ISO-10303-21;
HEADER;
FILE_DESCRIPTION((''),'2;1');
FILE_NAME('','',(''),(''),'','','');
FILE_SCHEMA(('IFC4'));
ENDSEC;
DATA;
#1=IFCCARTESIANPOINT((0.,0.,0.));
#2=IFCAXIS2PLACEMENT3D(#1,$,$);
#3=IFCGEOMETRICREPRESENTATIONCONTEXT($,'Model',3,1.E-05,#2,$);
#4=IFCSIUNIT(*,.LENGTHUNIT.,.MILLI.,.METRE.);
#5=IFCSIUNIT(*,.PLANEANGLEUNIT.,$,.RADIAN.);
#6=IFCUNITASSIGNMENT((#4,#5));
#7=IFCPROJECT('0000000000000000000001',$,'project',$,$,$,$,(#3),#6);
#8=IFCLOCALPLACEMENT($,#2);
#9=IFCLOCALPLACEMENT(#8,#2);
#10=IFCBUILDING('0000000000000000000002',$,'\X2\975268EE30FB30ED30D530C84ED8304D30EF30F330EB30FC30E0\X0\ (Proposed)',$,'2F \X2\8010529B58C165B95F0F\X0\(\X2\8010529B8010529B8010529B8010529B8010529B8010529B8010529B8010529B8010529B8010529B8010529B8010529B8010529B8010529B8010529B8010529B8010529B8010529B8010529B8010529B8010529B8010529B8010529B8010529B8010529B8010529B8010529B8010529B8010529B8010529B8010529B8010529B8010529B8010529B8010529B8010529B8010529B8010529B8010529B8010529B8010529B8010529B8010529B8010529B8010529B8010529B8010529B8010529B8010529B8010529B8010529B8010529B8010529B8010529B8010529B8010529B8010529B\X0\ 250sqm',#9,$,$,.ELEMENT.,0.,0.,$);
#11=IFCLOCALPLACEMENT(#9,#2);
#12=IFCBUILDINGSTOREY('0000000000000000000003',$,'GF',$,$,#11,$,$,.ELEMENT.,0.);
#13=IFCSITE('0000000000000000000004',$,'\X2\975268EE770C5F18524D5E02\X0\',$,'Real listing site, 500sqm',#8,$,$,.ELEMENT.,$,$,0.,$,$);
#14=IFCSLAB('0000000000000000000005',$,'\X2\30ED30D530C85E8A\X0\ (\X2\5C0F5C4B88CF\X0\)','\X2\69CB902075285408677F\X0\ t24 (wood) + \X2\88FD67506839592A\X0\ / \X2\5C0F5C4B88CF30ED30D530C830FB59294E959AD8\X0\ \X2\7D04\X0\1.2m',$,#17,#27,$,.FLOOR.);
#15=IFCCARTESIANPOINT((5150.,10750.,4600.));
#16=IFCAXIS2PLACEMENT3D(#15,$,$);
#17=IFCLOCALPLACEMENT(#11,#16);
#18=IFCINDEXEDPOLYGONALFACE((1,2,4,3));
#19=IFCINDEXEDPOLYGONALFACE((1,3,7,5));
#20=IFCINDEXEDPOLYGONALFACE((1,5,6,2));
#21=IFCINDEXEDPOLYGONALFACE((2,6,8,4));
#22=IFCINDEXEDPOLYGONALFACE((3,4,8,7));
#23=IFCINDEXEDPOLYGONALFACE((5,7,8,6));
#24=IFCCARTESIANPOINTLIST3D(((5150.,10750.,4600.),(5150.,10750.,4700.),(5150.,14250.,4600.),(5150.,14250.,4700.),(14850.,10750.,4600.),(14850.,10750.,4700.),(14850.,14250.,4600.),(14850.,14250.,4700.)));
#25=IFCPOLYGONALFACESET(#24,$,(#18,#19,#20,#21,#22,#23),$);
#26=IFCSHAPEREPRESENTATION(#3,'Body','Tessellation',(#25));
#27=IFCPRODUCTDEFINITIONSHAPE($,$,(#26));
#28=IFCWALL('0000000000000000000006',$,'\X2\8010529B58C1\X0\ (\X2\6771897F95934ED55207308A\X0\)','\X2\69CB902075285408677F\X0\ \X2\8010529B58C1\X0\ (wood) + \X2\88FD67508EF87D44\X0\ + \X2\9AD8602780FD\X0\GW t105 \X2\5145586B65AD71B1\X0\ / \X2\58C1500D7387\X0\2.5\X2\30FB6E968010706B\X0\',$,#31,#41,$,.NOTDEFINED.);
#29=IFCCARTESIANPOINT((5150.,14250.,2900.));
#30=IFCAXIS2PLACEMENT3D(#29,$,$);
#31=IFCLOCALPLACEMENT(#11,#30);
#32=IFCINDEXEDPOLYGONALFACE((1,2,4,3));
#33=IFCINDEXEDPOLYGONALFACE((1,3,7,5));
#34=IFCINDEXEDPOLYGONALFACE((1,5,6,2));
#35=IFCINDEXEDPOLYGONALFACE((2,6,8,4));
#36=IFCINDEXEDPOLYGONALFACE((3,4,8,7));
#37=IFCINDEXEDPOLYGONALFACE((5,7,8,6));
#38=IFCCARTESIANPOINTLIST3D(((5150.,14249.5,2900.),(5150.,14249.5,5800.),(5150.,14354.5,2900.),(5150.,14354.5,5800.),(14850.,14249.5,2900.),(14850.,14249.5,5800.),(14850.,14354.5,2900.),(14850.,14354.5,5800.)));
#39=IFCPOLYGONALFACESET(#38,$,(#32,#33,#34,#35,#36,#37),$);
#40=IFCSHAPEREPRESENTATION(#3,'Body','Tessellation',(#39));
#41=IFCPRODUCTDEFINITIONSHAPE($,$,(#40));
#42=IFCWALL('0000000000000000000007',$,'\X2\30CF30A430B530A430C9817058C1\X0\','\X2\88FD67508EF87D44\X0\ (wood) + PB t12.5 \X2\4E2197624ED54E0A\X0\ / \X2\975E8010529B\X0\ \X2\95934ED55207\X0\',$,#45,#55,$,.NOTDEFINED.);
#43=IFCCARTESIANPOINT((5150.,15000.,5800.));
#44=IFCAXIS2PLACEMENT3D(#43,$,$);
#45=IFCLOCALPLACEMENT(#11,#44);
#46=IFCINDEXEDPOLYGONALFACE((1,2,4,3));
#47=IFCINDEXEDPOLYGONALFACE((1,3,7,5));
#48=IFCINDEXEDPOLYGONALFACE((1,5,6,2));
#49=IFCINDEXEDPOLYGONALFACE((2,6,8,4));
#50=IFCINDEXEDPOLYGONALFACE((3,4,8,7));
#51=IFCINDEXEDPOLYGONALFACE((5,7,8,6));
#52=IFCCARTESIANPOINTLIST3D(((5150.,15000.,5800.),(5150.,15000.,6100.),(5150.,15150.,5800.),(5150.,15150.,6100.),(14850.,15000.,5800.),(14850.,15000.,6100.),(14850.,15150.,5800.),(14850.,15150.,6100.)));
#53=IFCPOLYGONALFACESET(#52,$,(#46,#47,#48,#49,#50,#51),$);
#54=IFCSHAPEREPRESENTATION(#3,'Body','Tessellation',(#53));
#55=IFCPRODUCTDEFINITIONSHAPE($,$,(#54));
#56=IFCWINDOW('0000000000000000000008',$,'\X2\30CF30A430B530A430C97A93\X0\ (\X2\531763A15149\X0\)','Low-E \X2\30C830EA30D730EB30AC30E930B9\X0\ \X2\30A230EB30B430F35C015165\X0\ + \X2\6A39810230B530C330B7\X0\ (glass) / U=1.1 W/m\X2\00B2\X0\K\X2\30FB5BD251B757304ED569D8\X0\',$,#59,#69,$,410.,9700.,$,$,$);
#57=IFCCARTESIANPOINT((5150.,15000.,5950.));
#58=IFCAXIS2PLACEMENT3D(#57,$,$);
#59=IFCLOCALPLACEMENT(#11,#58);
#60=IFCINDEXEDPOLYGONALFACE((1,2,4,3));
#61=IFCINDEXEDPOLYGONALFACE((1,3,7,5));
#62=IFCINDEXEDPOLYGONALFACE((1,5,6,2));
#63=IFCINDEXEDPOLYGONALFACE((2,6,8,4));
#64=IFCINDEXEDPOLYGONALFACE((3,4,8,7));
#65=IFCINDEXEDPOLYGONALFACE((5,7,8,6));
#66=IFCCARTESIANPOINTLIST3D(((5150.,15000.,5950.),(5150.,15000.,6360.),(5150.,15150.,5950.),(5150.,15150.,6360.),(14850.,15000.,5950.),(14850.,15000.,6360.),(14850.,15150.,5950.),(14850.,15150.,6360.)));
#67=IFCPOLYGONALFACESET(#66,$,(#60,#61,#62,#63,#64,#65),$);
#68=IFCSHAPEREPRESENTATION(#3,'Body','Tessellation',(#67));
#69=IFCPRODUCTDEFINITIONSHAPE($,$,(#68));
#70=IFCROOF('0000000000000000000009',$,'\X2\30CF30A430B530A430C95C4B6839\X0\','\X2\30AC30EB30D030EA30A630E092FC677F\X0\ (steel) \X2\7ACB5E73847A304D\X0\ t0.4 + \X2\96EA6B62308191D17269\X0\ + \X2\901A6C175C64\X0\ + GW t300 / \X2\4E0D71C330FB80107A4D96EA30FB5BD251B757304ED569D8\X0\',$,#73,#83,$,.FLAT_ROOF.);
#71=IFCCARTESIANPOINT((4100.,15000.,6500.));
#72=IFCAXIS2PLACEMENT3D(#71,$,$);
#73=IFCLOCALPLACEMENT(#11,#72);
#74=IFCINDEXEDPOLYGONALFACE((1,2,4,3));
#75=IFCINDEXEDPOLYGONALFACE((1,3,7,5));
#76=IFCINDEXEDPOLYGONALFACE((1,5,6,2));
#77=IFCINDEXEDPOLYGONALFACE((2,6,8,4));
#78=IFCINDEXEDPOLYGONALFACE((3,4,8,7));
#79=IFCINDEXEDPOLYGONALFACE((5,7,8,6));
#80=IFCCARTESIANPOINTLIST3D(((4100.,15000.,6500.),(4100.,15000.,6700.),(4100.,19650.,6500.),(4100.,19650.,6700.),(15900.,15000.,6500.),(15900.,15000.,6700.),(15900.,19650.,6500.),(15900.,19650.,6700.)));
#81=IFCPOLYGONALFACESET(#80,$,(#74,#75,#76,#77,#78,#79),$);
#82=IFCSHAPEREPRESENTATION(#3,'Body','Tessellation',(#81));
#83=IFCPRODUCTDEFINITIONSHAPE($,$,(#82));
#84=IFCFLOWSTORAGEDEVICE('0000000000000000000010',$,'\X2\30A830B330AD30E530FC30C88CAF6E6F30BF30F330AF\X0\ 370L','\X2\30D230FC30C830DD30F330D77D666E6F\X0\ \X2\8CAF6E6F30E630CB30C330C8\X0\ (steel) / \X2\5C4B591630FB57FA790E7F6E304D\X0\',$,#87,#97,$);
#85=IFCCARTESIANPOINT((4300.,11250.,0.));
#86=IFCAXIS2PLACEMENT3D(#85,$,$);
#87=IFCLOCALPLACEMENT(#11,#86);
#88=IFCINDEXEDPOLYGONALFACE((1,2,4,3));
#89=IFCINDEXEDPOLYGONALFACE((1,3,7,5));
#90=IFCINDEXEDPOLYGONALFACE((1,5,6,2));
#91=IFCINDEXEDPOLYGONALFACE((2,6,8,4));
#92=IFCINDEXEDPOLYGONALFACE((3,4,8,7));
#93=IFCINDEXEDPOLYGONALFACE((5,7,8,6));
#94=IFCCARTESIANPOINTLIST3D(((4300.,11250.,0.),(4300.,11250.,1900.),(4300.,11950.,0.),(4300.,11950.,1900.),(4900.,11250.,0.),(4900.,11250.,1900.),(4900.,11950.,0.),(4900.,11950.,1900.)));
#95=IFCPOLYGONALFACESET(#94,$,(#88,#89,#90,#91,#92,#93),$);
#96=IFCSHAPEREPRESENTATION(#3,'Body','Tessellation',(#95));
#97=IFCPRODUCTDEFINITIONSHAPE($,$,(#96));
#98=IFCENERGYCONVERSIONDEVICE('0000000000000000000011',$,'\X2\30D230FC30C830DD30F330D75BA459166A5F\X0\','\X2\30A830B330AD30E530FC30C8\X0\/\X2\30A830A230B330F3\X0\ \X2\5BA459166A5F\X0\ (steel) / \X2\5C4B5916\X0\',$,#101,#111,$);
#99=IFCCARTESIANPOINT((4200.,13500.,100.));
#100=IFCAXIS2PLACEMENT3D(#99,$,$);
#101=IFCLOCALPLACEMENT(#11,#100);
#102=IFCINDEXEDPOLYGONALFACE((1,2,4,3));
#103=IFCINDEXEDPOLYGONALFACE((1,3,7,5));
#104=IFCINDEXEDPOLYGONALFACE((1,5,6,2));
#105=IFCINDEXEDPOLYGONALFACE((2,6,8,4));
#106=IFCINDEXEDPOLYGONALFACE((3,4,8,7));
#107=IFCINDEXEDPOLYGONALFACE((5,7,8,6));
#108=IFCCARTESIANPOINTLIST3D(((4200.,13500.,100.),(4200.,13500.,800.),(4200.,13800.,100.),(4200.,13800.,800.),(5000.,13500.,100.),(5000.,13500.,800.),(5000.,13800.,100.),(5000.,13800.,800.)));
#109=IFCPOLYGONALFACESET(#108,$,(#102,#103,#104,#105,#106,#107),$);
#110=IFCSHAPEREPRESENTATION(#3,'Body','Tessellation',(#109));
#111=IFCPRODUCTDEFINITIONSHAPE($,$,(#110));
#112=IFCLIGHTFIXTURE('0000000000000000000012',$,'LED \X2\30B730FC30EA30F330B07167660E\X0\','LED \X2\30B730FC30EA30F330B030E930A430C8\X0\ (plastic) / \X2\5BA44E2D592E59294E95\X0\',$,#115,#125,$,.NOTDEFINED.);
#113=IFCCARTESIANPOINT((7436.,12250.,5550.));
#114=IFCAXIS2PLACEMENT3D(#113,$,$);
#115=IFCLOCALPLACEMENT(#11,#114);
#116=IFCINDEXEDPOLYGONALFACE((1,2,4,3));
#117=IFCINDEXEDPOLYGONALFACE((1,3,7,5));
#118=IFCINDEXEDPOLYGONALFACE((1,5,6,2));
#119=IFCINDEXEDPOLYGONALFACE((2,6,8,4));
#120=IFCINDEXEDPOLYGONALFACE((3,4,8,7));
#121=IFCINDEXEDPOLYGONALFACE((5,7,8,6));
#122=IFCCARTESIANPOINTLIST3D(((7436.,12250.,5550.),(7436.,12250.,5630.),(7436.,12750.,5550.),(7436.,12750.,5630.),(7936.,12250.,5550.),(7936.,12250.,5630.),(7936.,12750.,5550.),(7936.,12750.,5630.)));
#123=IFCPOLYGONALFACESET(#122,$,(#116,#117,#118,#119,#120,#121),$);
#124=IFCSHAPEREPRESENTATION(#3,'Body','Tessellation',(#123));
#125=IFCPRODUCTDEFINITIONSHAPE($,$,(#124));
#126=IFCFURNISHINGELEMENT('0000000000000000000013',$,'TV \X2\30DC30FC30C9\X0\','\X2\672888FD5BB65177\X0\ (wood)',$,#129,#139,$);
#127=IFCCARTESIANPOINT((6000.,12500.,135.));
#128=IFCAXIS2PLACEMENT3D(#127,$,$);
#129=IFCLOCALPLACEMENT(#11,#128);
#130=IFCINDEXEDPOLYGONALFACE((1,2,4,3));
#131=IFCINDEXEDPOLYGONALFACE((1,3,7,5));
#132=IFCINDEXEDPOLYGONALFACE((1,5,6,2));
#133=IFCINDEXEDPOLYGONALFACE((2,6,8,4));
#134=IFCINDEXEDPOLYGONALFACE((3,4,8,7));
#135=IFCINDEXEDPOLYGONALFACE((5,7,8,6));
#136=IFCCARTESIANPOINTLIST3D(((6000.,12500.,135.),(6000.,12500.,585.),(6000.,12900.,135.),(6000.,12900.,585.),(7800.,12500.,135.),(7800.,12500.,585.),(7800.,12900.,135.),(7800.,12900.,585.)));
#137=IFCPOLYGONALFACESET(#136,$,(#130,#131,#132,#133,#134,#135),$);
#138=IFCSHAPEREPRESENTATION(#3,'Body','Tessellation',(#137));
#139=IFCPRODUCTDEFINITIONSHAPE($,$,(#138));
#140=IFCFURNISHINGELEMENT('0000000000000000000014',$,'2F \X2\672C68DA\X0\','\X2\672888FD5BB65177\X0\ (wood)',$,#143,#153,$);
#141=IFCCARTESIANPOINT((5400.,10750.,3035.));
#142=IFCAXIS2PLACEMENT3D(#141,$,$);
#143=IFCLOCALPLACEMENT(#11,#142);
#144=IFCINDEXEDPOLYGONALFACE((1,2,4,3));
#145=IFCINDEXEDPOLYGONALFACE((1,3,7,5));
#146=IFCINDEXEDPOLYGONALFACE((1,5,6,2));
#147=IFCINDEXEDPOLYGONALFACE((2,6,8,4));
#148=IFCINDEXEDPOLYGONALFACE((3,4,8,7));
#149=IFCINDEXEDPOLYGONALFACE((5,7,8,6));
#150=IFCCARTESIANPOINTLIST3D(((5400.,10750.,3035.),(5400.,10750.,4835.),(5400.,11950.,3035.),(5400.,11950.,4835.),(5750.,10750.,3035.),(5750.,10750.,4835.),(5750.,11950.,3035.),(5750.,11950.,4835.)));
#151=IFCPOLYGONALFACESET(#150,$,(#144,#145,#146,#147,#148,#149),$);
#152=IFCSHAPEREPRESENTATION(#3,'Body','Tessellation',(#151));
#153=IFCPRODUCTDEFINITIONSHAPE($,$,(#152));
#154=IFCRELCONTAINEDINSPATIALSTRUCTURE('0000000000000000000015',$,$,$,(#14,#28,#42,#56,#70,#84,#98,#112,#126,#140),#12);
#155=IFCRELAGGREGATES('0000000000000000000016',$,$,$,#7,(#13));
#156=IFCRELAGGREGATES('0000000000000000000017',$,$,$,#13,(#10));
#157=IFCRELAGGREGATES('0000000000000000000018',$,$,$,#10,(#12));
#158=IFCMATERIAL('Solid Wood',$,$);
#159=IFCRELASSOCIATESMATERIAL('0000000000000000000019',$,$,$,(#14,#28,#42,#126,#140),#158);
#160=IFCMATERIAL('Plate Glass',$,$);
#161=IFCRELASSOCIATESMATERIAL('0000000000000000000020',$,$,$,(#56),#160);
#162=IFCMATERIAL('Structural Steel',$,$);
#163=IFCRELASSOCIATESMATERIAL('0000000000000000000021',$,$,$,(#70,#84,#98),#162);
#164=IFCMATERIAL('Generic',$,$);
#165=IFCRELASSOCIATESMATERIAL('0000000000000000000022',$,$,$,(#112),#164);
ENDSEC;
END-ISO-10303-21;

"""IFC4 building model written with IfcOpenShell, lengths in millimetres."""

from ifc_helpers import new_model, si_unit, frame, frame_2d, origin, place, context, project, spatial, rectangle, extrude, material, element, fill, save


model = new_model("IFC4")

# Units and contexts
model_context = context("Model", 3, precision=1e-05, world=origin())
ifc_project = project(units=[si_unit("LENGTHUNIT", "METRE", prefix="MILLI"), si_unit("PLANEANGLEUNIT", "RADIAN")], contexts=[model_context])

# Site, building, storey
site_placement = place(None, origin())
site = spatial("IfcSite", under=ifc_project, at=site_placement, Name="青森県弘前市", ObjectType="Real listing site, 500sqm", CompositionType="ELEMENT", RefElevation=0.0)
building_placement = place(site_placement, origin())
building = spatial("IfcBuilding", under=site, at=building_placement, Name="青森・ロフト付きワンルーム (Proposed)", ObjectType="2F 耐力壁方式(耐力耐力耐力耐力耐力耐力耐力耐力耐力耐力耐力耐力耐力耐力耐力耐力耐力耐力耐力耐力耐力耐力耐力耐力耐力耐力耐力耐力耐力耐力耐力耐力耐力耐力耐力耐力耐力耐力耐力耐力耐力耐力耐力耐力耐力耐力耐力耐力耐力耐力耐力耐力耐力耐力耐力耐力耐力 250sqm", CompositionType="ELEMENT", ElevationOfRefHeight=0.0, ElevationOfTerrain=0.0)
storey_placement = place(building_placement, origin())
storey = spatial("IfcBuildingStorey", under=building, at=storey_placement, Name="GF", CompositionType="ELEMENT", Elevation=0.0)

# Shared definitions
ifc_material_1 = material(Name="Solid Wood")

# Slab
slab_placement = place(storey_placement, frame((5150.0, 10750.0, 4600.0)))
element("IfcSlab", 1, at=slab_placement, inside=storey, material=ifc_material_1, Name="ロフト床 (小屋裏)", Description="構造用合板 t24 (wood) + 製材根太 / 小屋裏ロフト・天井高 約1.2m", PredefinedType="FLOOR", context=model_context, shape_type="SweptSolid", body=[
    extrude(rectangle(XDim=9700.0, YDim=3500.0, at=frame_2d((4850.0, 1750.0))), frame((5150.0, 10750.0, 4600.0)), (0.0, 0.0, 1.0), 100.0),
])

# Wall
wall_1_placement = place(storey_placement, frame((5150.0, 14250.0, 2900.0)))
element("IfcWall", 2, at=wall_1_placement, inside=storey, material=ifc_material_1, Name="耐力壁 (東西間仕切り)", Description="構造用合板 耐力壁 (wood) + 製材軸組 + 高性能GW t105 充填断熱 / 壁倍率2.5・準耐火", PredefinedType="NOTDEFINED", context=model_context, shape_type="SweptSolid", body=[
    extrude(rectangle(XDim=9700.0, YDim=105.0, at=frame_2d((4850.0, 52.0))), frame((5150.0, 14250.0, 2900.0)), (0.0, 0.0, 1.0), 2900.0),
])

# Wall, opening, window
wall_2_placement = place(storey_placement, frame((5150.0, 15000.0, 5800.0)))
wall_2 = element("IfcWall", 3, at=wall_2_placement, inside=storey, material=ifc_material_1, Name="ハイサイド腰壁", Description="製材軸組 (wood) + PB t12.5 両面仕上 / 非耐力 間仕切", PredefinedType="NOTDEFINED", context=model_context, shape_type="SweptSolid", body=[
    extrude(rectangle(XDim=9700.0, YDim=150.0, at=frame_2d((4850.0, 75.0))), frame((5150.0, 15000.0, 5800.0)), (0.0, 0.0, 1.0), 700.0),
])
opening_1_placement = place(storey_placement, frame((5150.0, 15000.0, 5950.0)))
opening_1 = element("IfcOpeningElement", 4, at=opening_1_placement, cuts=wall_2, PredefinedType="NOTDEFINED", context=model_context, shape_type="SweptSolid", body=[
    extrude(rectangle(XDim=9700.0, YDim=150.0, at=frame_2d((4850.0, 75.0))), frame((5150.0, 15000.0, 5950.0)), (0.0, 0.0, 1.0), 410.0),
])
ifc_material_2 = material(Name="Plate Glass")
window_placement = place(storey_placement, frame((5150.0, 15000.0, 5950.0)))
window = element("IfcWindow", 5, at=window_placement, inside=storey, material=ifc_material_2, Name="ハイサイド窓 (北採光)", Description="Low-E トリプルガラス アルゴン封入 + 樹脂サッシ (glass) / U=1.1 W/m²K・寒冷地仕様", OverallHeight=410.0, OverallWidth=9700.0, context=model_context, shape_type="SweptSolid", body=[
    extrude(rectangle(XDim=9700.0, YDim=150.0, at=frame_2d((4850.0, 75.0))), frame((5150.0, 15000.0, 5950.0)), (0.0, 0.0, 1.0), 410.0),
])
fill(opening_1, window)

# Roof
ifc_material_3 = material(Name="Structural Steel")
roof_placement = place(storey_placement, frame((4100.0, 15000.0, 6500.0)))
element("IfcRoof", 6, at=roof_placement, inside=storey, material=ifc_material_3, Name="ハイサイド屋根", Description="ガルバリウム鋼板 (steel) 立平葺き t0.4 + 雪止め金物 + 通気層 + GW t300 / 不燃・耐積雪・寒冷地仕様", PredefinedType="FLAT_ROOF", context=model_context, shape_type="SweptSolid", body=[
    extrude(rectangle(XDim=11800.0, YDim=4650.0, at=frame_2d((5900.0, 2325.0))), frame((4100.0, 15000.0, 6500.0)), (0.0, 0.0, 1.0), 200.0),
])

# Flow storage device
flow_storage_device_placement = place(storey_placement, frame((4300.0, 11250.0, 0.0)))
element("IfcFlowStorageDevice", 7, at=flow_storage_device_placement, inside=storey, material=ifc_material_3, Name="エコキュート貯湯タンク 370L", Description="ヒートポンプ給湯 貯湯ユニット (steel) / 屋外・基礎置き", context=model_context, shape_type="SweptSolid", body=[
    extrude(rectangle(XDim=600.0, YDim=700.0, at=frame_2d((300.0, 350.0))), frame((4300.0, 11250.0, 0.0)), (0.0, 0.0, 1.0), 1900.0),
])

# Energy conversion device
energy_conversion_device_placement = place(storey_placement, frame((4200.0, 13500.0, 100.0)))
element("IfcEnergyConversionDevice", 8, at=energy_conversion_device_placement, inside=storey, material=ifc_material_3, Name="ヒートポンプ室外機", Description="エコキュート/エアコン 室外機 (steel) / 屋外", context=model_context, shape_type="SweptSolid", body=[
    extrude(rectangle(XDim=800.0, YDim=300.0, at=frame_2d((400.0, 150.0))), frame((4200.0, 13500.0, 100.0)), (0.0, 0.0, 1.0), 700.0),
])

# Light fixture
ifc_material_4 = material(Name="Generic")
light_fixture_placement = place(storey_placement, frame((7436.0, 12250.0, 5550.0)))
element("IfcLightFixture", 9, at=light_fixture_placement, inside=storey, material=ifc_material_4, Name="LED シーリング照明", Description="LED シーリングライト (plastic) / 室中央天井", PredefinedType="NOTDEFINED", context=model_context, shape_type="SweptSolid", body=[
    extrude(rectangle(XDim=500.0, YDim=500.0, at=frame_2d((250.0, 250.0))), frame((7436.0, 12250.0, 5550.0)), (0.0, 0.0, 1.0), 80.0),
])

# Furnishing elements
furnishing_1_placement = place(storey_placement, frame((6000.0, 12500.0, 135.0)))
element("IfcFurnishingElement", 10, at=furnishing_1_placement, inside=storey, material=ifc_material_1, Name="TV ボード", Description="木製家具 (wood)", context=model_context, shape_type="SweptSolid", body=[
    extrude(rectangle(XDim=1800.0, YDim=400.0, at=frame_2d((900.0, 200.0))), frame((6000.0, 12500.0, 135.0)), (0.0, 0.0, 1.0), 450.0),
])
furnishing_2_placement = place(storey_placement, frame((5400.0, 10750.0, 3035.0)))
element("IfcFurnishingElement", 11, at=furnishing_2_placement, inside=storey, material=ifc_material_1, Name="2F 本棚", Description="木製家具 (wood)", context=model_context, shape_type="SweptSolid", body=[
    extrude(rectangle(XDim=350.0, YDim=1200.0, at=frame_2d((175.0, 600.0))), frame((5400.0, 10750.0, 3035.0)), (0.0, 0.0, 1.0), 1800.0),
])

save(model, "model.ifc")
